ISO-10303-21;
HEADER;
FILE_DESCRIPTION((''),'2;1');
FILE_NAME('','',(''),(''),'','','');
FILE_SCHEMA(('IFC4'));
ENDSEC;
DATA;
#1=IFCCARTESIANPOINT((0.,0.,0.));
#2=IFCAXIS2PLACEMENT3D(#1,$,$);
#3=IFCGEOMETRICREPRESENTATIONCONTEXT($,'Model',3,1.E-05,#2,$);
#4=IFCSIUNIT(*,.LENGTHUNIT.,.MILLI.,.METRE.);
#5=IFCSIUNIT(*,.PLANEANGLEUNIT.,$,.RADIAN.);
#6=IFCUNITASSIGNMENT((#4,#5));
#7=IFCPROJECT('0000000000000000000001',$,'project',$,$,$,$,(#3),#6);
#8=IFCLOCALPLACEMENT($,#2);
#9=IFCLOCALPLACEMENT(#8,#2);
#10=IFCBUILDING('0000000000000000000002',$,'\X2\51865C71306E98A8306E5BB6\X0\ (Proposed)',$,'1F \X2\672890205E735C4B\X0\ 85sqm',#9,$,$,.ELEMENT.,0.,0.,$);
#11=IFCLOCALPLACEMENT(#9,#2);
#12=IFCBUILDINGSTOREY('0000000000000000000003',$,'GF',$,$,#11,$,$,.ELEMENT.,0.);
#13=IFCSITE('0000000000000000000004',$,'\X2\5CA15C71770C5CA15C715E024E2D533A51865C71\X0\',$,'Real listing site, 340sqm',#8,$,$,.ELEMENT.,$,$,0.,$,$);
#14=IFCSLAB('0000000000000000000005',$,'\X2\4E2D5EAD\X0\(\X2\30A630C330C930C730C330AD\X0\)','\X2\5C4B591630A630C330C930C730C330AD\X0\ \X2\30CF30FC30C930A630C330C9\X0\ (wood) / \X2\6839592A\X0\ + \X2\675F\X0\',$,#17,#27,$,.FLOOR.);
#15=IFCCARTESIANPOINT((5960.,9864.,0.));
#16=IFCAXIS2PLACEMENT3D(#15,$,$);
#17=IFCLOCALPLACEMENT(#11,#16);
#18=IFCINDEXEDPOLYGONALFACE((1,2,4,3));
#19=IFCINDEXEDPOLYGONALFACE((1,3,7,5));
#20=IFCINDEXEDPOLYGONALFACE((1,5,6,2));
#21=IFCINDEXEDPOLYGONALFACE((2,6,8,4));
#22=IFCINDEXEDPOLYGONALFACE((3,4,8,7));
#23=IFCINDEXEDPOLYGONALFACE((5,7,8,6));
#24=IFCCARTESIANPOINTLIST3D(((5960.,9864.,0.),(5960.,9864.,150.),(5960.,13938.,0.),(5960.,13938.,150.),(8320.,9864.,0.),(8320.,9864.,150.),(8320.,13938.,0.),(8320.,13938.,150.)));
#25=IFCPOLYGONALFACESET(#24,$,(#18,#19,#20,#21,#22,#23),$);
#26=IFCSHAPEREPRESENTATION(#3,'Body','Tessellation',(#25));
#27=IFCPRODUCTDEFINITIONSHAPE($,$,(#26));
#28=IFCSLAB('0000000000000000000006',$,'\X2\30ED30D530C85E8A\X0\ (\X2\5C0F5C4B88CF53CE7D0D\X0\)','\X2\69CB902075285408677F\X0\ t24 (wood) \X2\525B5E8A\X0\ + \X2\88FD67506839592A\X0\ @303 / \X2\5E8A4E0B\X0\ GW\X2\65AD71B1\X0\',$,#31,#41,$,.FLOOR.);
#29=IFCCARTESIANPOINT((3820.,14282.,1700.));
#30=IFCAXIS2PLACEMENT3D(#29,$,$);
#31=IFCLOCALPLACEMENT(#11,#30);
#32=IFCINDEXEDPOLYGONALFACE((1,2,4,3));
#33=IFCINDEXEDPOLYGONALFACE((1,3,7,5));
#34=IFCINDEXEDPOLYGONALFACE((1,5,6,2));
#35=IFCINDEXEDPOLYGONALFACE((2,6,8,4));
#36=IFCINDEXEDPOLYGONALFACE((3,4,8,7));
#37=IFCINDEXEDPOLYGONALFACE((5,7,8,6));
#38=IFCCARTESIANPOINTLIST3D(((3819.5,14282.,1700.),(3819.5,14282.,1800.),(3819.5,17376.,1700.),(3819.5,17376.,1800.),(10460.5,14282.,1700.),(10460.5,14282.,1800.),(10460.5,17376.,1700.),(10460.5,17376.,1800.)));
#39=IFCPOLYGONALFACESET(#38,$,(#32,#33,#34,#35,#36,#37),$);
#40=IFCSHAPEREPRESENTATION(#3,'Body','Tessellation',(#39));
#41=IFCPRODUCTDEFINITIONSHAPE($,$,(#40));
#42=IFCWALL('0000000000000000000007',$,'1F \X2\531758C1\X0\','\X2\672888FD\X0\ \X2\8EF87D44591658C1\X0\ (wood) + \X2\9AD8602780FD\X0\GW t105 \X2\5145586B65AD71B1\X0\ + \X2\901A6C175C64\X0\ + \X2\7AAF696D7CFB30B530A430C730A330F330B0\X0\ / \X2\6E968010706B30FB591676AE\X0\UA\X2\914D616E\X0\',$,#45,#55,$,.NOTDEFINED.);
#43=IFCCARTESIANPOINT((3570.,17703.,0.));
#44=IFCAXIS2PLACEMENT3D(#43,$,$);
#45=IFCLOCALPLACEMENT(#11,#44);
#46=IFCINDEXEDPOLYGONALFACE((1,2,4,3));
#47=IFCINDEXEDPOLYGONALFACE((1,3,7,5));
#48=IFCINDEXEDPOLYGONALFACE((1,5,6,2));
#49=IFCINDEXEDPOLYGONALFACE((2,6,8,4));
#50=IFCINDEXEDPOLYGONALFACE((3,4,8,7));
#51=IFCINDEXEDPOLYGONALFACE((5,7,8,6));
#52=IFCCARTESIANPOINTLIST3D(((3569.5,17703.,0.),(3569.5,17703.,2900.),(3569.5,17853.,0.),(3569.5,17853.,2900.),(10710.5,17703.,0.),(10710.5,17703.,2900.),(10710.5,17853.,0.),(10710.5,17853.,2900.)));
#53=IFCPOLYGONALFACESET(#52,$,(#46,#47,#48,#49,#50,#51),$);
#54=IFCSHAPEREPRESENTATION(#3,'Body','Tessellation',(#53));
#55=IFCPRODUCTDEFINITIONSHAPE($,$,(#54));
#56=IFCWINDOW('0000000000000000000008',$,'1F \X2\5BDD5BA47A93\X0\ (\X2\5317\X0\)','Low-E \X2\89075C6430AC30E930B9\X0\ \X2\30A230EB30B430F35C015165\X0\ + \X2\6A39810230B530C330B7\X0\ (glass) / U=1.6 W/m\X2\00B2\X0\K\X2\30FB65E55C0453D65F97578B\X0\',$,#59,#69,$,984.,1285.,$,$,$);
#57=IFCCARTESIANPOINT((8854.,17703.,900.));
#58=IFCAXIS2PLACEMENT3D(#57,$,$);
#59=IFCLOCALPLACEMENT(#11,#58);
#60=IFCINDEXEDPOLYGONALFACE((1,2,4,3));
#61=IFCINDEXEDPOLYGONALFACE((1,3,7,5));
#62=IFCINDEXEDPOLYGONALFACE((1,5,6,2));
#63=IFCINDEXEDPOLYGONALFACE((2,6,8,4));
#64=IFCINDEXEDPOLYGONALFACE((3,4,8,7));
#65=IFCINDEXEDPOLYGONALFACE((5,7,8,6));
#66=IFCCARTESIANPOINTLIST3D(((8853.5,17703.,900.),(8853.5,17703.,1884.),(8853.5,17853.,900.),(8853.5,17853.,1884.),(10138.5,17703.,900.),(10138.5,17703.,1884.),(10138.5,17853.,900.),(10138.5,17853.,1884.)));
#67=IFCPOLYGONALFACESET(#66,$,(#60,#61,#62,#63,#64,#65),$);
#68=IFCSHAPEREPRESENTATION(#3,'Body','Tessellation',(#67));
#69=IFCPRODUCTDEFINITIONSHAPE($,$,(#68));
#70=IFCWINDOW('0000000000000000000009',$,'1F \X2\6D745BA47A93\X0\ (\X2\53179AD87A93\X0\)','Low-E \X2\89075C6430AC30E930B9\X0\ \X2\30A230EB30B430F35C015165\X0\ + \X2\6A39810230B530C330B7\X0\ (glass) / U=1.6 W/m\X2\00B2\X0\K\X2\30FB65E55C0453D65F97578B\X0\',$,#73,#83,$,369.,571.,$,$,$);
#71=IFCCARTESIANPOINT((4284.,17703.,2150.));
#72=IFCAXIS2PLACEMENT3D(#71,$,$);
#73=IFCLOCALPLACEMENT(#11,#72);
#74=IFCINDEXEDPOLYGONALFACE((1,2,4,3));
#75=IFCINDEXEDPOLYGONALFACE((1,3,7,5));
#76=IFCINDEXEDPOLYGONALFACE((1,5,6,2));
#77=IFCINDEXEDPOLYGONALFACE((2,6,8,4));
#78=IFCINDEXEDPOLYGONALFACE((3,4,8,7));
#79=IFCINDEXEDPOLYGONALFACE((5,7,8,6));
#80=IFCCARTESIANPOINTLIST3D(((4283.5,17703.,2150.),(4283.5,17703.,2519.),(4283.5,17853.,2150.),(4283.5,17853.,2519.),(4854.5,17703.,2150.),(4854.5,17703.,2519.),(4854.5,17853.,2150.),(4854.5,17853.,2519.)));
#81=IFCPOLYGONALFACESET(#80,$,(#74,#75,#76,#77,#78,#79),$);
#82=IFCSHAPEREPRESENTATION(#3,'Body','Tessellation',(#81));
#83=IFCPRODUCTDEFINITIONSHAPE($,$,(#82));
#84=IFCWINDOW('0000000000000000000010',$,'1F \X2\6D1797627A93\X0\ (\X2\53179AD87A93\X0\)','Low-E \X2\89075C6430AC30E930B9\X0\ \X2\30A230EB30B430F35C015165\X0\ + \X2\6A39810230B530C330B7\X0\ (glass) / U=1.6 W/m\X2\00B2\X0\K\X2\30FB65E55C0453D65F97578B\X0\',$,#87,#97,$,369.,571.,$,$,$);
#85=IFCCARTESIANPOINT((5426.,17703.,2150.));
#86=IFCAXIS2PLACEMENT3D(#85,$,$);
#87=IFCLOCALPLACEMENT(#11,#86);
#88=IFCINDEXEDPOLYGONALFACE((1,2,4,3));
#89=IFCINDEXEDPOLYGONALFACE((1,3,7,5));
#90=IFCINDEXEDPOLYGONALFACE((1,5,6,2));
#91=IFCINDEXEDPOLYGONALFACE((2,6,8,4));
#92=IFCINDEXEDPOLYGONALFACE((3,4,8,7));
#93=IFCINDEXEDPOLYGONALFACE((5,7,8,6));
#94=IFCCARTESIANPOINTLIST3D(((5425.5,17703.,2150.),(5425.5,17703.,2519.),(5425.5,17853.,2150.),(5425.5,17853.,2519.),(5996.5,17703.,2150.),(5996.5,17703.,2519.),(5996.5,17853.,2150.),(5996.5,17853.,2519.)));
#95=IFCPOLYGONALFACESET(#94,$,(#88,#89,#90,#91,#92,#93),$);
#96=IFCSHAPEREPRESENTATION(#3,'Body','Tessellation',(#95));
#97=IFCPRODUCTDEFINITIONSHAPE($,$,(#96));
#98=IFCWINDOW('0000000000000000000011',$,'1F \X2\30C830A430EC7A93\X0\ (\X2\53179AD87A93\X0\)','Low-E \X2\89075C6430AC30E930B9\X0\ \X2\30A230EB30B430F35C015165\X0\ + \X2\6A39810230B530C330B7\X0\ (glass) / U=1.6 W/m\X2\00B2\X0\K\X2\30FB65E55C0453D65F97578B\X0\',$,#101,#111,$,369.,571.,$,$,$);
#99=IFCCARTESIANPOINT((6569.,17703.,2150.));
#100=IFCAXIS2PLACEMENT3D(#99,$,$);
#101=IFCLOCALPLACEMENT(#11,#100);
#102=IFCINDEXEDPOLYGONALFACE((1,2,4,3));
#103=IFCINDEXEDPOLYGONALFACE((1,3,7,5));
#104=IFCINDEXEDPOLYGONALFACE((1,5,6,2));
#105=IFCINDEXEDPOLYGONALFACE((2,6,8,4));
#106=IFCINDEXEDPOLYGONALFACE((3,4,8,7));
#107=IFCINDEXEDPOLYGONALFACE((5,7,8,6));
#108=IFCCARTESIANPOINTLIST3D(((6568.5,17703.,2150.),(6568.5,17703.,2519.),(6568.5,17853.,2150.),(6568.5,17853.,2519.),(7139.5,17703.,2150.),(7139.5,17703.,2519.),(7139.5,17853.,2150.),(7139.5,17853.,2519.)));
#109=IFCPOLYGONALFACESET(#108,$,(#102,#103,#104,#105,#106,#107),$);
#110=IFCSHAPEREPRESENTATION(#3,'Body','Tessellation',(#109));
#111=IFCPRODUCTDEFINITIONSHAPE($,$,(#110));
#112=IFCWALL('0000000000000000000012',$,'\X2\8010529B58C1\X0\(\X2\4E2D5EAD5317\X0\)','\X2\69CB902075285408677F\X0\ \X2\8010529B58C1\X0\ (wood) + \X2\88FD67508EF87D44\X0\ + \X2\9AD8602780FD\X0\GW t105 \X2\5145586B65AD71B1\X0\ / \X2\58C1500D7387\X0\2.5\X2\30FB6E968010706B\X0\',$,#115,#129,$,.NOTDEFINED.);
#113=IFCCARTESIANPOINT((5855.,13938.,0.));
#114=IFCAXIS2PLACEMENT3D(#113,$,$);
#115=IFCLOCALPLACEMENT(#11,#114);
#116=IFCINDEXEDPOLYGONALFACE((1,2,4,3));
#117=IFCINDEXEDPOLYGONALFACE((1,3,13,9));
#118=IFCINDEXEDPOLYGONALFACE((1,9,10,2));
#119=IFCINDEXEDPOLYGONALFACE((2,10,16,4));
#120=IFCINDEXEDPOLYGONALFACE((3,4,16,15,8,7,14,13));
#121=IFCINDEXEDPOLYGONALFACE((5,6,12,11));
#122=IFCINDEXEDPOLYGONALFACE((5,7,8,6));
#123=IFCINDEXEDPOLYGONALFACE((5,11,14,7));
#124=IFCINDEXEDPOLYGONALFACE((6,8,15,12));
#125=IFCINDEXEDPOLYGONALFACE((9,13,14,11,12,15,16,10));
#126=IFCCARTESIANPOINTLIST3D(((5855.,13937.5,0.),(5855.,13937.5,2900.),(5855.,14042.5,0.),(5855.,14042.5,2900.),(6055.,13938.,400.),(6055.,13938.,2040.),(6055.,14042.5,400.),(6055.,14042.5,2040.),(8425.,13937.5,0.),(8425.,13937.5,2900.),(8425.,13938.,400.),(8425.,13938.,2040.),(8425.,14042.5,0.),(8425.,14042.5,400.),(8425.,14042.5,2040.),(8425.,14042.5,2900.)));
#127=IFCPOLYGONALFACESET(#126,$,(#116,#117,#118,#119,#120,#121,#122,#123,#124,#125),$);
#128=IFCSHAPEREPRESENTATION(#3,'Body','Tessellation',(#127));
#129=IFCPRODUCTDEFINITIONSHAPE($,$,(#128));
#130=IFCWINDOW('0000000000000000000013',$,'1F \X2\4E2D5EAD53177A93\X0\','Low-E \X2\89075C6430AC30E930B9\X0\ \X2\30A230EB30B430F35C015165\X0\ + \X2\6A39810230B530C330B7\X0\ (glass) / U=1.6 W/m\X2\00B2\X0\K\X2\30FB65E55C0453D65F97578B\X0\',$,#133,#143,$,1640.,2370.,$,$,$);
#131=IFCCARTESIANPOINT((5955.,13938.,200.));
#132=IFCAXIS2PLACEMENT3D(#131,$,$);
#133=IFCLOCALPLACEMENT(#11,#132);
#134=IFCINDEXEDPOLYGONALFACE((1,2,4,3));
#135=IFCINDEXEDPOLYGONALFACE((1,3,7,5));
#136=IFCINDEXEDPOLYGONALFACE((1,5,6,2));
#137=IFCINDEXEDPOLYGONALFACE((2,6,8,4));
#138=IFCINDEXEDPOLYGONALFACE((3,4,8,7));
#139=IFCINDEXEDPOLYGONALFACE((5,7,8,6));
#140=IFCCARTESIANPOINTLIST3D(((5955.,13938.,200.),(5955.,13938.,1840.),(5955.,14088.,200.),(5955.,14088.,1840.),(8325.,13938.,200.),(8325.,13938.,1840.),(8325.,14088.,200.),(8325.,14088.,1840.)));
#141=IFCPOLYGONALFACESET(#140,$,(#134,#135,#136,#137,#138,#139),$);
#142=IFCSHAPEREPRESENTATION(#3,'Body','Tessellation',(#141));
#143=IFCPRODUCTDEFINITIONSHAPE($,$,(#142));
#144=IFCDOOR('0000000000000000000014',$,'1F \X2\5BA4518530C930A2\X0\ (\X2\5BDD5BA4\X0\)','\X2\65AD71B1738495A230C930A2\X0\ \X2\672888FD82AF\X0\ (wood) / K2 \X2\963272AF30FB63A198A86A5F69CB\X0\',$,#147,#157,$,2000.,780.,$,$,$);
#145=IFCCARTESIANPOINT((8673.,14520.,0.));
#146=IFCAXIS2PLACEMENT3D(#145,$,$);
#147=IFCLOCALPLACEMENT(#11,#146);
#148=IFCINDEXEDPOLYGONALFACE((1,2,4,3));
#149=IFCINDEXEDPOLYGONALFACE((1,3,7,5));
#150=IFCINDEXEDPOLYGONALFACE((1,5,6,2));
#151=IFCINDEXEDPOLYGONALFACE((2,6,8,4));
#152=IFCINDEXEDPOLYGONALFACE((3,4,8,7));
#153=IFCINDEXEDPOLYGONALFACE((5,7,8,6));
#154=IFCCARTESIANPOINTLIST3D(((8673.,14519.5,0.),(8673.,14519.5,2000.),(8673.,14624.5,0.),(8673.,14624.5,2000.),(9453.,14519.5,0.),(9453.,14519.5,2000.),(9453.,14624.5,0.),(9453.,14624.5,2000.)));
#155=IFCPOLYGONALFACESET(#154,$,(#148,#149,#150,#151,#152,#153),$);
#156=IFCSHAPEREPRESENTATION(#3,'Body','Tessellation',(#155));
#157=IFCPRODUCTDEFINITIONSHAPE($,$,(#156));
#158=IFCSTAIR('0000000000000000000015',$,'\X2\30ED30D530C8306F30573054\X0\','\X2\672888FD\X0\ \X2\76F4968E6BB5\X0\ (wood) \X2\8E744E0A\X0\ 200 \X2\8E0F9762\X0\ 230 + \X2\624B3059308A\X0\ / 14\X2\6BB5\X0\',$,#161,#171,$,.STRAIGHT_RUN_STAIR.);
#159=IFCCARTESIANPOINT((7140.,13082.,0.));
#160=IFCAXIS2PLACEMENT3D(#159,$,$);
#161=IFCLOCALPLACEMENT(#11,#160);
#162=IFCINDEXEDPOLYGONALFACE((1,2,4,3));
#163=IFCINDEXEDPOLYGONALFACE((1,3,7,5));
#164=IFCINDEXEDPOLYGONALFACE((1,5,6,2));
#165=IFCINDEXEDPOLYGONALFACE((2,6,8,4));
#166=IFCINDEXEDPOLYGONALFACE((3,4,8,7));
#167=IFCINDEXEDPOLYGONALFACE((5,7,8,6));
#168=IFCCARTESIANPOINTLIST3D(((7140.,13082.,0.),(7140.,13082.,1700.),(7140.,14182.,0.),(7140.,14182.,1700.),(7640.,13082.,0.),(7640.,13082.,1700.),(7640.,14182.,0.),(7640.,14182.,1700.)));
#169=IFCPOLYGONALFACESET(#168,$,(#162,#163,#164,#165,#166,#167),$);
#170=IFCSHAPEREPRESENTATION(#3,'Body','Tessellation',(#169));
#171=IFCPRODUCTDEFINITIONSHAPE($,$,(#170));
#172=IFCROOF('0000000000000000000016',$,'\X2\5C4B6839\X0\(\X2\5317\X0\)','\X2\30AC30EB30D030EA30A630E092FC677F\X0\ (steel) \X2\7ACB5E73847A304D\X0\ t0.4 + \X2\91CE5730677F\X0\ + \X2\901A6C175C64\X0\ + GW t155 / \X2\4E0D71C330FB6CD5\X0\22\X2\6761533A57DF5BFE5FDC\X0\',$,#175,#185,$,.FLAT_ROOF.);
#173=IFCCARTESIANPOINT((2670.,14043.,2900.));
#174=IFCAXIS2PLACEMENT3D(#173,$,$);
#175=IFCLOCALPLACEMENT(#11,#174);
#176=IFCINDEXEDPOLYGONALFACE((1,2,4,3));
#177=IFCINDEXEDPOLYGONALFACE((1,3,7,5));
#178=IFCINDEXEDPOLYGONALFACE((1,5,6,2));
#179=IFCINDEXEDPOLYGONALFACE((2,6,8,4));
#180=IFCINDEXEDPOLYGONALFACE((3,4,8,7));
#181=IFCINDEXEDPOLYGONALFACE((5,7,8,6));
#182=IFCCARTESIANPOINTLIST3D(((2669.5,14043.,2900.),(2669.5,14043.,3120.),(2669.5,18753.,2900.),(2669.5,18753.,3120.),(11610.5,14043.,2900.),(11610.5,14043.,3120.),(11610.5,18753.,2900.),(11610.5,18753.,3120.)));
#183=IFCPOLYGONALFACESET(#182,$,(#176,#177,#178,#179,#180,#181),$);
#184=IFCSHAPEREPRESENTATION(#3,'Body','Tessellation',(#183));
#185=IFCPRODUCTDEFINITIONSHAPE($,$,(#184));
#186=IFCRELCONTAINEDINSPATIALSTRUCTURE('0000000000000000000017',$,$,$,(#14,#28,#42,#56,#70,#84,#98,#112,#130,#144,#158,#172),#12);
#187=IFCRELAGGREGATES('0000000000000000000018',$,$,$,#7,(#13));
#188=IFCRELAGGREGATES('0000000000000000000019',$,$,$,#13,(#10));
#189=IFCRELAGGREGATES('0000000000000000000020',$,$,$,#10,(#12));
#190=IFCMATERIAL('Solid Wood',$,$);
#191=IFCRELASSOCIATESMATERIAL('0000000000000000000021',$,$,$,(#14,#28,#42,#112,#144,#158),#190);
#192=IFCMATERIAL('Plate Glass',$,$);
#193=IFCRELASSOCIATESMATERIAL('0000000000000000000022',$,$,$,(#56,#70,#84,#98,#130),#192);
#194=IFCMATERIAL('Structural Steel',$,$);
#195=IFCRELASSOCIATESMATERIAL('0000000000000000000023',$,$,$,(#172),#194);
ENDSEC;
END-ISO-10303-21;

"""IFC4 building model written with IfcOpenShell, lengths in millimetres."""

from ifc_helpers import new_model, si_unit, frame, frame_2d, origin, place, context, project, spatial, rectangle, extrude, material, element, fill, save


model = new_model("IFC4")

# Units and contexts
model_context = context("Model", 3, precision=1e-05, world=origin())
ifc_project = project(units=[si_unit("LENGTHUNIT", "METRE", prefix="MILLI"), si_unit("PLANEANGLEUNIT", "RADIAN")], contexts=[model_context])

# Site, building, storey
site_placement = place(None, origin())
site = spatial("IfcSite", under=ifc_project, at=site_placement, Name="岡山県岡山市中区円山", ObjectType="Real listing site, 340sqm", CompositionType="ELEMENT", RefElevation=0.0)
building_placement = place(site_placement, origin())
building = spatial("IfcBuilding", under=site, at=building_placement, Name="円山の風の家 (Proposed)", ObjectType="1F 木造平屋 85sqm", CompositionType="ELEMENT", ElevationOfRefHeight=0.0, ElevationOfTerrain=0.0)
storey_placement = place(building_placement, origin())
storey = spatial("IfcBuildingStorey", under=building, at=storey_placement, Name="GF", CompositionType="ELEMENT", Elevation=0.0)

# Slabs
ifc_material_1 = material(Name="Solid Wood")
slab_1_placement = place(storey_placement, frame((5960.0, 9864.0, 0.0)))
element("IfcSlab", 1, at=slab_1_placement, inside=storey, material=ifc_material_1, Name="中庭(ウッドデッキ)", Description="屋外ウッドデッキ ハードウッド (wood) / 根太 + 束", PredefinedType="FLOOR", context=model_context, shape_type="SweptSolid", body=[
    extrude(rectangle(XDim=2360.0, YDim=4074.0, at=frame_2d((1180.0, 2037.0))), frame((5960.0, 9864.0, 0.0)), (0.0, 0.0, 1.0), 150.0),
])
slab_2_placement = place(storey_placement, frame((3820.0, 14282.0, 1700.0)))
element("IfcSlab", 2, at=slab_2_placement, inside=storey, material=ifc_material_1, Name="ロフト床 (小屋裏収納)", Description="構造用合板 t24 (wood) 剛床 + 製材根太 @303 / 床下 GW断熱", PredefinedType="FLOOR", context=model_context, shape_type="SweptSolid", body=[
    extrude(rectangle(XDim=6641.0, YDim=3094.0, at=frame_2d((3320.0, 1547.0))), frame((3820.0, 14282.0, 1700.0)), (0.0, 0.0, 1.0), 100.0),
])

# Wall, openings, windows
wall_1_placement = place(storey_placement, frame((3570.0, 17703.0, 0.0)))
wall_1 = element("IfcWall", 3, at=wall_1_placement, inside=storey, material=ifc_material_1, Name="1F 北壁", Description="木製 軸組外壁 (wood) + 高性能GW t105 充填断熱 + 通気層 + 窯業系サイディング / 準耐火・外皮UA配慮", PredefinedType="NOTDEFINED", context=model_context, shape_type="SweptSolid", body=[
    extrude(rectangle(XDim=7141.0, YDim=150.0, at=frame_2d((3570.0, 75.0))), frame((3570.0, 17703.0, 0.0)), (0.0, 0.0, 1.0), 2900.0),
])
opening_1_placement = place(storey_placement, frame((8854.0, 17703.0, 900.0)))
opening_1 = element("IfcOpeningElement", 4, at=opening_1_placement, cuts=wall_1, PredefinedType="NOTDEFINED", context=model_context, shape_type="SweptSolid", body=[
    extrude(rectangle(XDim=1285.0, YDim=150.0, at=frame_2d((642.0, 75.0))), frame((8854.0, 17703.0, 900.0)), (0.0, 0.0, 1.0), 984.0),
])
opening_2_placement = place(storey_placement, frame((4284.0, 17703.0, 2150.0)))
opening_2 = element("IfcOpeningElement", 5, at=opening_2_placement, cuts=wall_1, PredefinedType="NOTDEFINED", context=model_context, shape_type="SweptSolid", body=[
    extrude(rectangle(XDim=571.0, YDim=150.0, at=frame_2d((285.0, 75.0))), frame((4284.0, 17703.0, 2150.0)), (0.0, 0.0, 1.0), 369.0),
])
opening_3_placement = place(storey_placement, frame((5426.0, 17703.0, 2150.0)))
opening_3 = element("IfcOpeningElement", 6, at=opening_3_placement, cuts=wall_1, PredefinedType="NOTDEFINED", context=model_context, shape_type="SweptSolid", body=[
    extrude(rectangle(XDim=571.0, YDim=150.0, at=frame_2d((285.0, 75.0))), frame((5426.0, 17703.0, 2150.0)), (0.0, 0.0, 1.0), 369.0),
])
opening_4_placement = place(storey_placement, frame((6569.0, 17703.0, 2150.0)))
opening_4 = element("IfcOpeningElement", 7, at=opening_4_placement, cuts=wall_1, PredefinedType="NOTDEFINED", context=model_context, shape_type="SweptSolid", body=[
    extrude(rectangle(XDim=571.0, YDim=150.0, at=frame_2d((285.0, 75.0))), frame((6569.0, 17703.0, 2150.0)), (0.0, 0.0, 1.0), 369.0),
])
ifc_material_2 = material(Name="Plate Glass")
window_1_placement = place(storey_placement, frame((8854.0, 17703.0, 900.0)))
window_1 = element("IfcWindow", 8, at=window_1_placement, inside=storey, material=ifc_material_2, Name="1F 寝室窓 (北)", Description="Low-E 複層ガラス アルゴン封入 + 樹脂サッシ (glass) / U=1.6 W/m²K・日射取得型", OverallHeight=984.0, OverallWidth=1285.0, context=model_context, shape_type="SweptSolid", body=[
    extrude(rectangle(XDim=1285.0, YDim=150.0, at=frame_2d((642.0, 75.0))), frame((8854.0, 17703.0, 900.0)), (0.0, 0.0, 1.0), 984.0),
])
fill(opening_1, window_1)
window_2_placement = place(storey_placement, frame((4284.0, 17703.0, 2150.0)))
window_2 = element("IfcWindow", 9, at=window_2_placement, inside=storey, material=ifc_material_2, Name="1F 浴室窓 (北高窓)", Description="Low-E 複層ガラス アルゴン封入 + 樹脂サッシ (glass) / U=1.6 W/m²K・日射取得型", OverallHeight=369.0, OverallWidth=571.0, context=model_context, shape_type="SweptSolid", body=[
    extrude(rectangle(XDim=571.0, YDim=150.0, at=frame_2d((285.0, 75.0))), frame((4284.0, 17703.0, 2150.0)), (0.0, 0.0, 1.0), 369.0),
])
fill(opening_2, window_2)
window_3_placement = place(storey_placement, frame((5426.0, 17703.0, 2150.0)))
window_3 = element("IfcWindow", 10, at=window_3_placement, inside=storey, material=ifc_material_2, Name="1F 洗面窓 (北高窓)", Description="Low-E 複層ガラス アルゴン封入 + 樹脂サッシ (glass) / U=1.6 W/m²K・日射取得型", OverallHeight=369.0, OverallWidth=571.0, context=model_context, shape_type="SweptSolid", body=[
    extrude(rectangle(XDim=571.0, YDim=150.0, at=frame_2d((285.0, 75.0))), frame((5426.0, 17703.0, 2150.0)), (0.0, 0.0, 1.0), 369.0),
])
fill(opening_3, window_3)
window_4_placement = place(storey_placement, frame((6569.0, 17703.0, 2150.0)))
window_4 = element("IfcWindow", 11, at=window_4_placement, inside=storey, material=ifc_material_2, Name="1F トイレ窓 (北高窓)", Description="Low-E 複層ガラス アルゴン封入 + 樹脂サッシ (glass) / U=1.6 W/m²K・日射取得型", OverallHeight=369.0, OverallWidth=571.0, context=model_context, shape_type="SweptSolid", body=[
    extrude(rectangle(XDim=571.0, YDim=150.0, at=frame_2d((285.0, 75.0))), frame((6569.0, 17703.0, 2150.0)), (0.0, 0.0, 1.0), 369.0),
])
fill(opening_4, window_4)

# Wall, opening, window
wall_2_placement = place(storey_placement, frame((5855.0, 13938.0, 0.0)))
wall_2 = element("IfcWall", 12, at=wall_2_placement, inside=storey, material=ifc_material_1, Name="耐力壁(中庭北)", Description="構造用合板 耐力壁 (wood) + 製材軸組 + 高性能GW t105 充填断熱 / 壁倍率2.5・準耐火", PredefinedType="NOTDEFINED", context=model_context, shape_type="SweptSolid", body=[
    extrude(rectangle(XDim=2570.0, YDim=105.0, at=frame_2d((1285.0, 52.0))), frame((5855.0, 13938.0, 0.0)), (0.0, 0.0, 1.0), 2900.0),
])
opening_5_placement = place(storey_placement, frame((5955.0, 13938.0, 200.0)))
opening_5 = element("IfcOpeningElement", 13, at=opening_5_placement, cuts=wall_2, PredefinedType="NOTDEFINED", context=model_context, shape_type="SweptSolid", body=[
    extrude(rectangle(XDim=2370.0, YDim=150.0, at=frame_2d((1185.0, 75.0))), frame((5955.0, 13938.0, 200.0)), (0.0, 0.0, 1.0), 1640.0),
])
window_5_placement = place(storey_placement, frame((5955.0, 13938.0, 200.0)))
window_5 = element("IfcWindow", 14, at=window_5_placement, inside=storey, material=ifc_material_2, Name="1F 中庭北窓", Description="Low-E 複層ガラス アルゴン封入 + 樹脂サッシ (glass) / U=1.6 W/m²K・日射取得型", OverallHeight=1640.0, OverallWidth=2370.0, context=model_context, shape_type="SweptSolid", body=[
    extrude(rectangle(XDim=2370.0, YDim=150.0, at=frame_2d((1185.0, 75.0))), frame((5955.0, 13938.0, 200.0)), (0.0, 0.0, 1.0), 1640.0),
])
fill(opening_5, window_5)

# Door
door_1_placement = place(storey_placement, frame((8673.0, 14520.0, 0.0)))
element("IfcDoor", 15, at=door_1_placement, inside=storey, material=ifc_material_1, Name="1F 室内ドア (寝室)", Description="断熱玄関ドア 木製芯 (wood) / K2 防犯・採風機構", OverallHeight=2000.0, OverallWidth=780.0, context=model_context, shape_type="SweptSolid", body=[
    extrude(rectangle(XDim=780.0, YDim=105.0, at=frame_2d((390.0, 52.0))), frame((8673.0, 14520.0, 0.0)), (0.0, 0.0, 1.0), 2000.0),
])

# Stair
stair_placement = place(storey_placement, frame((7140.0, 13082.0, 0.0)))
element("IfcStair", 16, at=stair_placement, inside=storey, material=ifc_material_1, Name="ロフトはしご", Description="木製 直階段 (wood) 蹴上 200 踏面 230 + 手すり / 14段", PredefinedType="STRAIGHT_RUN_STAIR", context=model_context, shape_type="SweptSolid", body=[
    extrude(rectangle(XDim=500.0, YDim=1100.0, at=frame_2d((250.0, 550.0))), frame((7140.0, 13082.0, 0.0)), (0.0, 0.0, 1.0), 1700.0),
])

# Roof
ifc_material_3 = material(Name="Structural Steel")
roof_1_placement = place(storey_placement, frame((2670.0, 14043.0, 2900.0)))
element("IfcRoof", 17, at=roof_1_placement, inside=storey, material=ifc_material_3, Name="屋根(北)", Description="ガルバリウム鋼板 (steel) 立平葺き t0.4 + 野地板 + 通気層 + GW t155 / 不燃・法22条区域対応", PredefinedType="FLAT_ROOF", context=model_context, shape_type="SweptSolid", body=[
    extrude(rectangle(XDim=8941.0, YDim=4710.0, at=frame_2d((4470.0, 2355.0))), frame((2670.0, 14043.0, 2900.0)), (0.0, 0.0, 1.0), 220.0),
])

save(model, "model.ifc")
